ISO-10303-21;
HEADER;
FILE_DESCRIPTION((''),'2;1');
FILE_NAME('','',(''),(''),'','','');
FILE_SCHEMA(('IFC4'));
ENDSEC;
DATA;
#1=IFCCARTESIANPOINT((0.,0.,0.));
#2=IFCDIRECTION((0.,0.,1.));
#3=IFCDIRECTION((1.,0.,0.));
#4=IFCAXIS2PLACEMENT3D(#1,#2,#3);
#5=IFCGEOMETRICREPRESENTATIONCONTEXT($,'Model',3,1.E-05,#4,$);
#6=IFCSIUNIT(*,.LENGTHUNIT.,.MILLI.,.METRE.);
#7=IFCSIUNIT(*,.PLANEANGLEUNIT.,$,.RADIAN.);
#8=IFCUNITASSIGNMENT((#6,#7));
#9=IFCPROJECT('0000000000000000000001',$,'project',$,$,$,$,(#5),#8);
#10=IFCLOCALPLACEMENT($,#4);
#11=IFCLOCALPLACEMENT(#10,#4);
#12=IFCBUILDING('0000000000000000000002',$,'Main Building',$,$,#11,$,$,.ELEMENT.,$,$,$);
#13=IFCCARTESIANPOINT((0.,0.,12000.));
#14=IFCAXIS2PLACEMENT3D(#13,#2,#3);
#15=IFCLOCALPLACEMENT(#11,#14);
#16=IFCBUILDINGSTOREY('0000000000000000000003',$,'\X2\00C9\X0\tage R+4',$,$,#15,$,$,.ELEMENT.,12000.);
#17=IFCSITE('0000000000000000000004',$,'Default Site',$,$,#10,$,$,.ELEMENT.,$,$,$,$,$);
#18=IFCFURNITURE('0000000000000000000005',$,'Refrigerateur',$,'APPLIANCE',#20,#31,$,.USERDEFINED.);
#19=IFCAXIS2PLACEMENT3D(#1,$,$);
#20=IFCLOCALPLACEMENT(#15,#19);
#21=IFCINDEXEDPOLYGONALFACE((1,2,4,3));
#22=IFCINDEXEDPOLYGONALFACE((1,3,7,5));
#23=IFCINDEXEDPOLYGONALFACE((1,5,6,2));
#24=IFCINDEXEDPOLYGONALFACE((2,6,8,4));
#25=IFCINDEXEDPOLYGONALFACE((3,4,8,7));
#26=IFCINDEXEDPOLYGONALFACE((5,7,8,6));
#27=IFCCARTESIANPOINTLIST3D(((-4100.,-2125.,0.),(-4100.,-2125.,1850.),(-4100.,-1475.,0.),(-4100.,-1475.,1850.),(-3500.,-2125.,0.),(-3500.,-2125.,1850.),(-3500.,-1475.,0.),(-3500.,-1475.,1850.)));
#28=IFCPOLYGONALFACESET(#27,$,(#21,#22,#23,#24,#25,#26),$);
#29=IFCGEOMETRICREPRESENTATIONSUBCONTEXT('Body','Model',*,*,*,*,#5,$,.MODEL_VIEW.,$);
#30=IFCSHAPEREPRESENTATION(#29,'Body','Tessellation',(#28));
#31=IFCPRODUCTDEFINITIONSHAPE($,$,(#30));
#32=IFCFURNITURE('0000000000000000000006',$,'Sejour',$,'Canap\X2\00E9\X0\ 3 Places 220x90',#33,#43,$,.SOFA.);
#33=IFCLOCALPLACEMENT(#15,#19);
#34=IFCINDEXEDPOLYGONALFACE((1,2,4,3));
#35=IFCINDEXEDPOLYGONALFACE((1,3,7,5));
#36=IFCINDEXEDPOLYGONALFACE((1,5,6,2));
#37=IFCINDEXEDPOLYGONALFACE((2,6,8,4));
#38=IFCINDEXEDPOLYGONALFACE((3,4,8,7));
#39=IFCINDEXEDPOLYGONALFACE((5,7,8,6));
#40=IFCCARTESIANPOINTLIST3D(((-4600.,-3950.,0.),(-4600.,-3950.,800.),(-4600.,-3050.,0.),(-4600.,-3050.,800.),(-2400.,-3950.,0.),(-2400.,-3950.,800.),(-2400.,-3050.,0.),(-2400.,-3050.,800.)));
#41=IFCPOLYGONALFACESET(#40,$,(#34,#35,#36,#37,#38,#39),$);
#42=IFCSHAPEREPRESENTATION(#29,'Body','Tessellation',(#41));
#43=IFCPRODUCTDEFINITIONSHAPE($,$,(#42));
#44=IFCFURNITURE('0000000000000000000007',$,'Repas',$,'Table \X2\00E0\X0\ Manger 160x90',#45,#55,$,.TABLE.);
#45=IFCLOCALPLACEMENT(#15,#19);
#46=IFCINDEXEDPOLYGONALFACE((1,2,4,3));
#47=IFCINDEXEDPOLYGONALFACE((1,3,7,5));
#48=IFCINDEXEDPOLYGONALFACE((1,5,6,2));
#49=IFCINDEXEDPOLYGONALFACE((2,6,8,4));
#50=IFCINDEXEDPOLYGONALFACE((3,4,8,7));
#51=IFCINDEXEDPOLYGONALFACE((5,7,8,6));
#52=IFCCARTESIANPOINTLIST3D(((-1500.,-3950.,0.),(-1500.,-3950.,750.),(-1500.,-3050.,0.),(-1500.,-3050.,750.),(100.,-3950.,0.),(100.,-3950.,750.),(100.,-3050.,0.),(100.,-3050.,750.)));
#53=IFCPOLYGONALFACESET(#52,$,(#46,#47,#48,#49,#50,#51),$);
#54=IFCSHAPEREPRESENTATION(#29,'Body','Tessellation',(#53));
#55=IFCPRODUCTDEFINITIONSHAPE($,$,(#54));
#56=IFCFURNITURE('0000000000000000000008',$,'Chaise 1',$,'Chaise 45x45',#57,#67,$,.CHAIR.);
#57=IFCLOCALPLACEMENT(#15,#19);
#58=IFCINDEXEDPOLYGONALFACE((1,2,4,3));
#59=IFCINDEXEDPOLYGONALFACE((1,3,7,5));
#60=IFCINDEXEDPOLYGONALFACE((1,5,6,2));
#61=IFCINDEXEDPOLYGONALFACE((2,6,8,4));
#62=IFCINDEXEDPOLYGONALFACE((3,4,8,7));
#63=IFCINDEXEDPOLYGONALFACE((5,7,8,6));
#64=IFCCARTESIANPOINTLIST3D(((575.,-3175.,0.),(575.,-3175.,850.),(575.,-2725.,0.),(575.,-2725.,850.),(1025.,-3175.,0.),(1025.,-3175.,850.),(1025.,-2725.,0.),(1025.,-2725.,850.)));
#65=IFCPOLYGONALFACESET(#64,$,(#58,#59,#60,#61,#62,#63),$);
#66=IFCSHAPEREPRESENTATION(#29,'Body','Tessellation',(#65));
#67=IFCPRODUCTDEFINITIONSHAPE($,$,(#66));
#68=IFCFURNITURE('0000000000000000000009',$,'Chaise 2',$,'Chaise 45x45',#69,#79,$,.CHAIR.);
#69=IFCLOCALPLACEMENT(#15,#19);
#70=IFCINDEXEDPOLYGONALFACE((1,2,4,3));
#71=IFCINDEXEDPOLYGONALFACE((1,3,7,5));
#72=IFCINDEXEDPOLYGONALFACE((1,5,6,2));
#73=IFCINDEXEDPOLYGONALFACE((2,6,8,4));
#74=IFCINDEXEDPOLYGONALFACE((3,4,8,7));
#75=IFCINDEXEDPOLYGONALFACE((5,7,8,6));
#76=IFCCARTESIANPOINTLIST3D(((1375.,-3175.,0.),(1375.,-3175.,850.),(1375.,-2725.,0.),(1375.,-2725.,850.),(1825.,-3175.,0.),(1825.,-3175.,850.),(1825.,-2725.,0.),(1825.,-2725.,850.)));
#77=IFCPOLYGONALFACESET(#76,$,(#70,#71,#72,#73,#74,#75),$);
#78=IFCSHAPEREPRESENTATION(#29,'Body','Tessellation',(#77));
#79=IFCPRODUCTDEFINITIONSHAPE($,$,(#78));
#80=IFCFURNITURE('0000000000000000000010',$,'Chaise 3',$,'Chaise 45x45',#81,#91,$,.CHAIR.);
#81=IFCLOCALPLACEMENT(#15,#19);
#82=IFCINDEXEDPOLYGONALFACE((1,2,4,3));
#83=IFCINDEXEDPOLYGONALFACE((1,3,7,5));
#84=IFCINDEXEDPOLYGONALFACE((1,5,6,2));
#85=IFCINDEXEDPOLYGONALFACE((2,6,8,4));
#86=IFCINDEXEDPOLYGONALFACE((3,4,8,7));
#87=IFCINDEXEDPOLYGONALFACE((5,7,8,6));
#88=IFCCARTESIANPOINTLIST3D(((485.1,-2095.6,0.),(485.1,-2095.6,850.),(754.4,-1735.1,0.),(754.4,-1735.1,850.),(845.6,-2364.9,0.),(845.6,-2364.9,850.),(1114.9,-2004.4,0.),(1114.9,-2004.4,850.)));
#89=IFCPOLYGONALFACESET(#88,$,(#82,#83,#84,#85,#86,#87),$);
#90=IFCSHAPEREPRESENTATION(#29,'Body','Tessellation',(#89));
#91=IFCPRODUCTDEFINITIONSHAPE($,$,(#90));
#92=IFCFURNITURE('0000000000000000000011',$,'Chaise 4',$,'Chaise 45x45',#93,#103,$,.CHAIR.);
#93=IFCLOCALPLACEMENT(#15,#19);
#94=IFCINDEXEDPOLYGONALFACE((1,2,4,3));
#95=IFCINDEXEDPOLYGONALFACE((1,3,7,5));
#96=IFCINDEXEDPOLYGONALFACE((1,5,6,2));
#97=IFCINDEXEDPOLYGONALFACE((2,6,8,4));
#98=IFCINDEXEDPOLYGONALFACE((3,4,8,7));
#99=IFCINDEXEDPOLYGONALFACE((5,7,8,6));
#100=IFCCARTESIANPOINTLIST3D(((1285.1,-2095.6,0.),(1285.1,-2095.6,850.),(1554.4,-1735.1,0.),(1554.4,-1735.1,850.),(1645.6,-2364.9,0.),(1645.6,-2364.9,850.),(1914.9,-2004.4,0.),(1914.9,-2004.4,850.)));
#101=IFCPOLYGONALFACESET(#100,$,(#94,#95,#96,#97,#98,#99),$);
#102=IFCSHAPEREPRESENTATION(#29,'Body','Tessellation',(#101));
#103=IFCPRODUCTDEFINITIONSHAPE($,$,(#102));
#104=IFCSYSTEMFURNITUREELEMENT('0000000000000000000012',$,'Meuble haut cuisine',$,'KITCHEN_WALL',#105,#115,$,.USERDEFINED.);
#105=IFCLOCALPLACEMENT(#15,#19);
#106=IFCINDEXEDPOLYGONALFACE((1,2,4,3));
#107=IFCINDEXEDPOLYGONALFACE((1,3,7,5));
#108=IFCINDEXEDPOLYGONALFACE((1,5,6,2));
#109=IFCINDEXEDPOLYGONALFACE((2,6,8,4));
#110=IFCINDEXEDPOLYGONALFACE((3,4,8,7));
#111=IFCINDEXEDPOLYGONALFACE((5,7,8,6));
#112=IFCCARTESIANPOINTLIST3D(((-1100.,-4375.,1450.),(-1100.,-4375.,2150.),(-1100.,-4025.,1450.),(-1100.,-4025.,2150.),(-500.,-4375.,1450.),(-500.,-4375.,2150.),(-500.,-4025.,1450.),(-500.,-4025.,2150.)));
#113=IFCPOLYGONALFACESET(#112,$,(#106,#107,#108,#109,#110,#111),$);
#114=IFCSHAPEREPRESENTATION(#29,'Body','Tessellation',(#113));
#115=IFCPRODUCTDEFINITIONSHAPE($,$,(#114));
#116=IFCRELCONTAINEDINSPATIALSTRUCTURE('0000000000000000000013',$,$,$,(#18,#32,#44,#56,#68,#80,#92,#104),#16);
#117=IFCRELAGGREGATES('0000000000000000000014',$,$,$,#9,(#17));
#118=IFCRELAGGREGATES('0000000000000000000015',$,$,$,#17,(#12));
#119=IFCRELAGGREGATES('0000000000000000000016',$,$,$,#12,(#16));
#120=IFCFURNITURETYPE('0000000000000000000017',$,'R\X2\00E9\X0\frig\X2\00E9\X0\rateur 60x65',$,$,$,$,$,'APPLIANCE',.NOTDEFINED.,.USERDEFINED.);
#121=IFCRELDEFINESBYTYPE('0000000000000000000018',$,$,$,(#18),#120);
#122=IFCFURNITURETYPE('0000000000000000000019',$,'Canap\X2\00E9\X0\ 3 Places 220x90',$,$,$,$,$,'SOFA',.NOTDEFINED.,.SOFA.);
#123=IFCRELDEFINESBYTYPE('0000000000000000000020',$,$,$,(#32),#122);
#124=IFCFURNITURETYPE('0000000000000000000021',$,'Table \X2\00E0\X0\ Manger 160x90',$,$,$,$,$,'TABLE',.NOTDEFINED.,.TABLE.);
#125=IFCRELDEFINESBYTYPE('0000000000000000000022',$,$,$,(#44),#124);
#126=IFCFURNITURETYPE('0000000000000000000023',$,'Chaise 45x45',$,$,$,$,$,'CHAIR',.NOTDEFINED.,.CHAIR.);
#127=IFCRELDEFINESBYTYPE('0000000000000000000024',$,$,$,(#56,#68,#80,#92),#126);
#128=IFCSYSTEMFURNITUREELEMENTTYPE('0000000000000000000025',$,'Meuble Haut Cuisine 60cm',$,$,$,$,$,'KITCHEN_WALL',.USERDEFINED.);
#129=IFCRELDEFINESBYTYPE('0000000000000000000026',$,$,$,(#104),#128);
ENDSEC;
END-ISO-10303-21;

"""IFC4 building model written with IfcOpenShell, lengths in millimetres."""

from ifc_helpers import new_model, si_unit, frame, origin_with_axes, place, context, subcontext, project, spatial, polyline, outline, extrude, type_object, element, save


model = new_model("IFC4")

# Units and contexts
model_context = context("Model", 3, precision=1e-05, world=origin_with_axes())
body_context = subcontext(model_context, "Body", "Model", "MODEL_VIEW")
ifc_project = project(units=[si_unit("LENGTHUNIT", "METRE", prefix="MILLI"), si_unit("PLANEANGLEUNIT", "RADIAN")], contexts=[model_context])

# Site, building, storey
site_placement = place(None, origin_with_axes())
site = spatial("IfcSite", under=ifc_project, at=site_placement, Name="Default Site", CompositionType="ELEMENT")
building_placement = place(site_placement, origin_with_axes())
building = spatial("IfcBuilding", under=site, at=building_placement, Name="Main Building", CompositionType="ELEMENT")
storey_placement = place(building_placement, frame((0.0, 0.0, 12000.0), z_axis=(0.0, 0.0, 1.0), x_axis=(1.0, 0.0, 0.0)))
storey = spatial("IfcBuildingStorey", under=building, at=storey_placement, Name="Étage R+4", CompositionType="ELEMENT", Elevation=12000.0)

# Furniture
furniture_type_1 = type_object("IfcFurnitureType", Name="Réfrigérateur 60x65", ElementType="APPLIANCE", AssemblyPlace="NOTDEFINED", PredefinedType="USERDEFINED")
furniture_1_placement = place(storey_placement, frame((-3800.0, -1800.0, 0.0), z_axis=(0.0, 0.0, 1.0), x_axis=(1.0, 0.0, 0.0)))
element("IfcFurniture", 1, at=furniture_1_placement, inside=storey, type_object=furniture_type_1, Name="Refrigerateur", ObjectType="APPLIANCE", PredefinedType="USERDEFINED", context=body_context, shape_type="SweptSolid", body=[
    extrude(outline(polyline([(-300.0, -325.0), (300.0, -325.0), (300.0, 325.0), (-300.0, 325.0), (-300.0, -325.0)])), origin_with_axes(), (0.0, 0.0, 1.0), 1850.0),
])
furniture_type_2 = type_object("IfcFurnitureType", Name="Canapé 3 Places 220x90", ElementType="SOFA", AssemblyPlace="NOTDEFINED", PredefinedType="SOFA")
furniture_2_placement = place(storey_placement, frame((-3500.0, -3500.0, 0.0), z_axis=(0.0, 0.0, 1.0), x_axis=(1.0, 0.0, 0.0)))
element("IfcFurniture", 2, at=furniture_2_placement, inside=storey, type_object=furniture_type_2, Name="Sejour", ObjectType="Canapé 3 Places 220x90", PredefinedType="SOFA", context=body_context, shape_type="SweptSolid", body=[
    extrude(outline(polyline([(-1100.0, -450.0), (1100.0, -450.0), (1100.0, 450.0), (-1100.0, 450.0), (-1100.0, -450.0)])), origin_with_axes(), (0.0, 0.0, 1.0), 800.0),
])
furniture_type_3 = type_object("IfcFurnitureType", Name="Table à Manger 160x90", ElementType="TABLE", AssemblyPlace="NOTDEFINED", PredefinedType="TABLE")
furniture_3_placement = place(storey_placement, frame((-700.0, -3500.0, 0.0), z_axis=(0.0, 0.0, 1.0), x_axis=(1.0, 0.0, 0.0)))
element("IfcFurniture", 3, at=furniture_3_placement, inside=storey, type_object=furniture_type_3, Name="Repas", ObjectType="Table à Manger 160x90", PredefinedType="TABLE", context=body_context, shape_type="SweptSolid", body=[
    extrude(outline(polyline([(-800.0, -450.0), (800.0, -450.0), (800.0, 450.0), (-800.0, 450.0), (-800.0, -450.0)])), origin_with_axes(), (0.0, 0.0, 1.0), 750.0),
])
furniture_type_4 = type_object("IfcFurnitureType", Name="Chaise 45x45", ElementType="CHAIR", AssemblyPlace="NOTDEFINED", PredefinedType="CHAIR")
for number, where, z_axis, x_axis, name in (
    (4, (800.0, -2950.0, 0.0), (0.0, 0.0, 1.0), (1.0, 0.0, 0.0), "Chaise 1"),
    (5, (1600.0, -2950.0, 0.0), (0.0, 0.0, 1.0), (1.0, 0.0, 0.0), "Chaise 2"),
    (6, (800.0, -2050.0, 0.0), (0.0, 0.0, 1.0), (-0.59846, -0.801153, 0.0), "Chaise 3"),
    (7, (1600.0, -2050.0, 0.0), (0.0, 0.0, 1.0), (-0.59846, -0.801153, 0.0), "Chaise 4"),
):
    element("IfcFurniture", number, at=place(storey_placement, frame(where, z_axis=z_axis, x_axis=x_axis)), inside=storey, type_object=furniture_type_4, Name=name, ObjectType="Chaise 45x45", PredefinedType="CHAIR", context=body_context, shape_type="SweptSolid", body=[
        extrude(outline(polyline([(-225.0, -225.0), (225.0, -225.0), (225.0, 225.0), (-225.0, 225.0), (-225.0, -225.0)])), origin_with_axes(), (0.0, 0.0, 1.0), 850.0),
    ])

# System furniture element
system_furniture_element_type = type_object("IfcSystemFurnitureElementType", Name="Meuble Haut Cuisine 60cm", ElementType="KITCHEN_WALL", PredefinedType="USERDEFINED")
system_furniture_element_placement = place(storey_placement, frame((-800.0, -4200.0, 1450.0), z_axis=(0.0, 0.0, 1.0), x_axis=(1.0, 0.0, 0.0)))
element("IfcSystemFurnitureElement", 8, at=system_furniture_element_placement, inside=storey, type_object=system_furniture_element_type, Name="Meuble haut cuisine", ObjectType="KITCHEN_WALL", PredefinedType="USERDEFINED", context=body_context, shape_type="SweptSolid", body=[
    extrude(outline(polyline([(-300.0, -175.0), (300.0, -175.0), (300.0, 175.0), (-300.0, 175.0), (-300.0, -175.0)])), origin_with_axes(), (0.0, 0.0, 1.0), 700.0),
])

save(model, "model.ifc")
